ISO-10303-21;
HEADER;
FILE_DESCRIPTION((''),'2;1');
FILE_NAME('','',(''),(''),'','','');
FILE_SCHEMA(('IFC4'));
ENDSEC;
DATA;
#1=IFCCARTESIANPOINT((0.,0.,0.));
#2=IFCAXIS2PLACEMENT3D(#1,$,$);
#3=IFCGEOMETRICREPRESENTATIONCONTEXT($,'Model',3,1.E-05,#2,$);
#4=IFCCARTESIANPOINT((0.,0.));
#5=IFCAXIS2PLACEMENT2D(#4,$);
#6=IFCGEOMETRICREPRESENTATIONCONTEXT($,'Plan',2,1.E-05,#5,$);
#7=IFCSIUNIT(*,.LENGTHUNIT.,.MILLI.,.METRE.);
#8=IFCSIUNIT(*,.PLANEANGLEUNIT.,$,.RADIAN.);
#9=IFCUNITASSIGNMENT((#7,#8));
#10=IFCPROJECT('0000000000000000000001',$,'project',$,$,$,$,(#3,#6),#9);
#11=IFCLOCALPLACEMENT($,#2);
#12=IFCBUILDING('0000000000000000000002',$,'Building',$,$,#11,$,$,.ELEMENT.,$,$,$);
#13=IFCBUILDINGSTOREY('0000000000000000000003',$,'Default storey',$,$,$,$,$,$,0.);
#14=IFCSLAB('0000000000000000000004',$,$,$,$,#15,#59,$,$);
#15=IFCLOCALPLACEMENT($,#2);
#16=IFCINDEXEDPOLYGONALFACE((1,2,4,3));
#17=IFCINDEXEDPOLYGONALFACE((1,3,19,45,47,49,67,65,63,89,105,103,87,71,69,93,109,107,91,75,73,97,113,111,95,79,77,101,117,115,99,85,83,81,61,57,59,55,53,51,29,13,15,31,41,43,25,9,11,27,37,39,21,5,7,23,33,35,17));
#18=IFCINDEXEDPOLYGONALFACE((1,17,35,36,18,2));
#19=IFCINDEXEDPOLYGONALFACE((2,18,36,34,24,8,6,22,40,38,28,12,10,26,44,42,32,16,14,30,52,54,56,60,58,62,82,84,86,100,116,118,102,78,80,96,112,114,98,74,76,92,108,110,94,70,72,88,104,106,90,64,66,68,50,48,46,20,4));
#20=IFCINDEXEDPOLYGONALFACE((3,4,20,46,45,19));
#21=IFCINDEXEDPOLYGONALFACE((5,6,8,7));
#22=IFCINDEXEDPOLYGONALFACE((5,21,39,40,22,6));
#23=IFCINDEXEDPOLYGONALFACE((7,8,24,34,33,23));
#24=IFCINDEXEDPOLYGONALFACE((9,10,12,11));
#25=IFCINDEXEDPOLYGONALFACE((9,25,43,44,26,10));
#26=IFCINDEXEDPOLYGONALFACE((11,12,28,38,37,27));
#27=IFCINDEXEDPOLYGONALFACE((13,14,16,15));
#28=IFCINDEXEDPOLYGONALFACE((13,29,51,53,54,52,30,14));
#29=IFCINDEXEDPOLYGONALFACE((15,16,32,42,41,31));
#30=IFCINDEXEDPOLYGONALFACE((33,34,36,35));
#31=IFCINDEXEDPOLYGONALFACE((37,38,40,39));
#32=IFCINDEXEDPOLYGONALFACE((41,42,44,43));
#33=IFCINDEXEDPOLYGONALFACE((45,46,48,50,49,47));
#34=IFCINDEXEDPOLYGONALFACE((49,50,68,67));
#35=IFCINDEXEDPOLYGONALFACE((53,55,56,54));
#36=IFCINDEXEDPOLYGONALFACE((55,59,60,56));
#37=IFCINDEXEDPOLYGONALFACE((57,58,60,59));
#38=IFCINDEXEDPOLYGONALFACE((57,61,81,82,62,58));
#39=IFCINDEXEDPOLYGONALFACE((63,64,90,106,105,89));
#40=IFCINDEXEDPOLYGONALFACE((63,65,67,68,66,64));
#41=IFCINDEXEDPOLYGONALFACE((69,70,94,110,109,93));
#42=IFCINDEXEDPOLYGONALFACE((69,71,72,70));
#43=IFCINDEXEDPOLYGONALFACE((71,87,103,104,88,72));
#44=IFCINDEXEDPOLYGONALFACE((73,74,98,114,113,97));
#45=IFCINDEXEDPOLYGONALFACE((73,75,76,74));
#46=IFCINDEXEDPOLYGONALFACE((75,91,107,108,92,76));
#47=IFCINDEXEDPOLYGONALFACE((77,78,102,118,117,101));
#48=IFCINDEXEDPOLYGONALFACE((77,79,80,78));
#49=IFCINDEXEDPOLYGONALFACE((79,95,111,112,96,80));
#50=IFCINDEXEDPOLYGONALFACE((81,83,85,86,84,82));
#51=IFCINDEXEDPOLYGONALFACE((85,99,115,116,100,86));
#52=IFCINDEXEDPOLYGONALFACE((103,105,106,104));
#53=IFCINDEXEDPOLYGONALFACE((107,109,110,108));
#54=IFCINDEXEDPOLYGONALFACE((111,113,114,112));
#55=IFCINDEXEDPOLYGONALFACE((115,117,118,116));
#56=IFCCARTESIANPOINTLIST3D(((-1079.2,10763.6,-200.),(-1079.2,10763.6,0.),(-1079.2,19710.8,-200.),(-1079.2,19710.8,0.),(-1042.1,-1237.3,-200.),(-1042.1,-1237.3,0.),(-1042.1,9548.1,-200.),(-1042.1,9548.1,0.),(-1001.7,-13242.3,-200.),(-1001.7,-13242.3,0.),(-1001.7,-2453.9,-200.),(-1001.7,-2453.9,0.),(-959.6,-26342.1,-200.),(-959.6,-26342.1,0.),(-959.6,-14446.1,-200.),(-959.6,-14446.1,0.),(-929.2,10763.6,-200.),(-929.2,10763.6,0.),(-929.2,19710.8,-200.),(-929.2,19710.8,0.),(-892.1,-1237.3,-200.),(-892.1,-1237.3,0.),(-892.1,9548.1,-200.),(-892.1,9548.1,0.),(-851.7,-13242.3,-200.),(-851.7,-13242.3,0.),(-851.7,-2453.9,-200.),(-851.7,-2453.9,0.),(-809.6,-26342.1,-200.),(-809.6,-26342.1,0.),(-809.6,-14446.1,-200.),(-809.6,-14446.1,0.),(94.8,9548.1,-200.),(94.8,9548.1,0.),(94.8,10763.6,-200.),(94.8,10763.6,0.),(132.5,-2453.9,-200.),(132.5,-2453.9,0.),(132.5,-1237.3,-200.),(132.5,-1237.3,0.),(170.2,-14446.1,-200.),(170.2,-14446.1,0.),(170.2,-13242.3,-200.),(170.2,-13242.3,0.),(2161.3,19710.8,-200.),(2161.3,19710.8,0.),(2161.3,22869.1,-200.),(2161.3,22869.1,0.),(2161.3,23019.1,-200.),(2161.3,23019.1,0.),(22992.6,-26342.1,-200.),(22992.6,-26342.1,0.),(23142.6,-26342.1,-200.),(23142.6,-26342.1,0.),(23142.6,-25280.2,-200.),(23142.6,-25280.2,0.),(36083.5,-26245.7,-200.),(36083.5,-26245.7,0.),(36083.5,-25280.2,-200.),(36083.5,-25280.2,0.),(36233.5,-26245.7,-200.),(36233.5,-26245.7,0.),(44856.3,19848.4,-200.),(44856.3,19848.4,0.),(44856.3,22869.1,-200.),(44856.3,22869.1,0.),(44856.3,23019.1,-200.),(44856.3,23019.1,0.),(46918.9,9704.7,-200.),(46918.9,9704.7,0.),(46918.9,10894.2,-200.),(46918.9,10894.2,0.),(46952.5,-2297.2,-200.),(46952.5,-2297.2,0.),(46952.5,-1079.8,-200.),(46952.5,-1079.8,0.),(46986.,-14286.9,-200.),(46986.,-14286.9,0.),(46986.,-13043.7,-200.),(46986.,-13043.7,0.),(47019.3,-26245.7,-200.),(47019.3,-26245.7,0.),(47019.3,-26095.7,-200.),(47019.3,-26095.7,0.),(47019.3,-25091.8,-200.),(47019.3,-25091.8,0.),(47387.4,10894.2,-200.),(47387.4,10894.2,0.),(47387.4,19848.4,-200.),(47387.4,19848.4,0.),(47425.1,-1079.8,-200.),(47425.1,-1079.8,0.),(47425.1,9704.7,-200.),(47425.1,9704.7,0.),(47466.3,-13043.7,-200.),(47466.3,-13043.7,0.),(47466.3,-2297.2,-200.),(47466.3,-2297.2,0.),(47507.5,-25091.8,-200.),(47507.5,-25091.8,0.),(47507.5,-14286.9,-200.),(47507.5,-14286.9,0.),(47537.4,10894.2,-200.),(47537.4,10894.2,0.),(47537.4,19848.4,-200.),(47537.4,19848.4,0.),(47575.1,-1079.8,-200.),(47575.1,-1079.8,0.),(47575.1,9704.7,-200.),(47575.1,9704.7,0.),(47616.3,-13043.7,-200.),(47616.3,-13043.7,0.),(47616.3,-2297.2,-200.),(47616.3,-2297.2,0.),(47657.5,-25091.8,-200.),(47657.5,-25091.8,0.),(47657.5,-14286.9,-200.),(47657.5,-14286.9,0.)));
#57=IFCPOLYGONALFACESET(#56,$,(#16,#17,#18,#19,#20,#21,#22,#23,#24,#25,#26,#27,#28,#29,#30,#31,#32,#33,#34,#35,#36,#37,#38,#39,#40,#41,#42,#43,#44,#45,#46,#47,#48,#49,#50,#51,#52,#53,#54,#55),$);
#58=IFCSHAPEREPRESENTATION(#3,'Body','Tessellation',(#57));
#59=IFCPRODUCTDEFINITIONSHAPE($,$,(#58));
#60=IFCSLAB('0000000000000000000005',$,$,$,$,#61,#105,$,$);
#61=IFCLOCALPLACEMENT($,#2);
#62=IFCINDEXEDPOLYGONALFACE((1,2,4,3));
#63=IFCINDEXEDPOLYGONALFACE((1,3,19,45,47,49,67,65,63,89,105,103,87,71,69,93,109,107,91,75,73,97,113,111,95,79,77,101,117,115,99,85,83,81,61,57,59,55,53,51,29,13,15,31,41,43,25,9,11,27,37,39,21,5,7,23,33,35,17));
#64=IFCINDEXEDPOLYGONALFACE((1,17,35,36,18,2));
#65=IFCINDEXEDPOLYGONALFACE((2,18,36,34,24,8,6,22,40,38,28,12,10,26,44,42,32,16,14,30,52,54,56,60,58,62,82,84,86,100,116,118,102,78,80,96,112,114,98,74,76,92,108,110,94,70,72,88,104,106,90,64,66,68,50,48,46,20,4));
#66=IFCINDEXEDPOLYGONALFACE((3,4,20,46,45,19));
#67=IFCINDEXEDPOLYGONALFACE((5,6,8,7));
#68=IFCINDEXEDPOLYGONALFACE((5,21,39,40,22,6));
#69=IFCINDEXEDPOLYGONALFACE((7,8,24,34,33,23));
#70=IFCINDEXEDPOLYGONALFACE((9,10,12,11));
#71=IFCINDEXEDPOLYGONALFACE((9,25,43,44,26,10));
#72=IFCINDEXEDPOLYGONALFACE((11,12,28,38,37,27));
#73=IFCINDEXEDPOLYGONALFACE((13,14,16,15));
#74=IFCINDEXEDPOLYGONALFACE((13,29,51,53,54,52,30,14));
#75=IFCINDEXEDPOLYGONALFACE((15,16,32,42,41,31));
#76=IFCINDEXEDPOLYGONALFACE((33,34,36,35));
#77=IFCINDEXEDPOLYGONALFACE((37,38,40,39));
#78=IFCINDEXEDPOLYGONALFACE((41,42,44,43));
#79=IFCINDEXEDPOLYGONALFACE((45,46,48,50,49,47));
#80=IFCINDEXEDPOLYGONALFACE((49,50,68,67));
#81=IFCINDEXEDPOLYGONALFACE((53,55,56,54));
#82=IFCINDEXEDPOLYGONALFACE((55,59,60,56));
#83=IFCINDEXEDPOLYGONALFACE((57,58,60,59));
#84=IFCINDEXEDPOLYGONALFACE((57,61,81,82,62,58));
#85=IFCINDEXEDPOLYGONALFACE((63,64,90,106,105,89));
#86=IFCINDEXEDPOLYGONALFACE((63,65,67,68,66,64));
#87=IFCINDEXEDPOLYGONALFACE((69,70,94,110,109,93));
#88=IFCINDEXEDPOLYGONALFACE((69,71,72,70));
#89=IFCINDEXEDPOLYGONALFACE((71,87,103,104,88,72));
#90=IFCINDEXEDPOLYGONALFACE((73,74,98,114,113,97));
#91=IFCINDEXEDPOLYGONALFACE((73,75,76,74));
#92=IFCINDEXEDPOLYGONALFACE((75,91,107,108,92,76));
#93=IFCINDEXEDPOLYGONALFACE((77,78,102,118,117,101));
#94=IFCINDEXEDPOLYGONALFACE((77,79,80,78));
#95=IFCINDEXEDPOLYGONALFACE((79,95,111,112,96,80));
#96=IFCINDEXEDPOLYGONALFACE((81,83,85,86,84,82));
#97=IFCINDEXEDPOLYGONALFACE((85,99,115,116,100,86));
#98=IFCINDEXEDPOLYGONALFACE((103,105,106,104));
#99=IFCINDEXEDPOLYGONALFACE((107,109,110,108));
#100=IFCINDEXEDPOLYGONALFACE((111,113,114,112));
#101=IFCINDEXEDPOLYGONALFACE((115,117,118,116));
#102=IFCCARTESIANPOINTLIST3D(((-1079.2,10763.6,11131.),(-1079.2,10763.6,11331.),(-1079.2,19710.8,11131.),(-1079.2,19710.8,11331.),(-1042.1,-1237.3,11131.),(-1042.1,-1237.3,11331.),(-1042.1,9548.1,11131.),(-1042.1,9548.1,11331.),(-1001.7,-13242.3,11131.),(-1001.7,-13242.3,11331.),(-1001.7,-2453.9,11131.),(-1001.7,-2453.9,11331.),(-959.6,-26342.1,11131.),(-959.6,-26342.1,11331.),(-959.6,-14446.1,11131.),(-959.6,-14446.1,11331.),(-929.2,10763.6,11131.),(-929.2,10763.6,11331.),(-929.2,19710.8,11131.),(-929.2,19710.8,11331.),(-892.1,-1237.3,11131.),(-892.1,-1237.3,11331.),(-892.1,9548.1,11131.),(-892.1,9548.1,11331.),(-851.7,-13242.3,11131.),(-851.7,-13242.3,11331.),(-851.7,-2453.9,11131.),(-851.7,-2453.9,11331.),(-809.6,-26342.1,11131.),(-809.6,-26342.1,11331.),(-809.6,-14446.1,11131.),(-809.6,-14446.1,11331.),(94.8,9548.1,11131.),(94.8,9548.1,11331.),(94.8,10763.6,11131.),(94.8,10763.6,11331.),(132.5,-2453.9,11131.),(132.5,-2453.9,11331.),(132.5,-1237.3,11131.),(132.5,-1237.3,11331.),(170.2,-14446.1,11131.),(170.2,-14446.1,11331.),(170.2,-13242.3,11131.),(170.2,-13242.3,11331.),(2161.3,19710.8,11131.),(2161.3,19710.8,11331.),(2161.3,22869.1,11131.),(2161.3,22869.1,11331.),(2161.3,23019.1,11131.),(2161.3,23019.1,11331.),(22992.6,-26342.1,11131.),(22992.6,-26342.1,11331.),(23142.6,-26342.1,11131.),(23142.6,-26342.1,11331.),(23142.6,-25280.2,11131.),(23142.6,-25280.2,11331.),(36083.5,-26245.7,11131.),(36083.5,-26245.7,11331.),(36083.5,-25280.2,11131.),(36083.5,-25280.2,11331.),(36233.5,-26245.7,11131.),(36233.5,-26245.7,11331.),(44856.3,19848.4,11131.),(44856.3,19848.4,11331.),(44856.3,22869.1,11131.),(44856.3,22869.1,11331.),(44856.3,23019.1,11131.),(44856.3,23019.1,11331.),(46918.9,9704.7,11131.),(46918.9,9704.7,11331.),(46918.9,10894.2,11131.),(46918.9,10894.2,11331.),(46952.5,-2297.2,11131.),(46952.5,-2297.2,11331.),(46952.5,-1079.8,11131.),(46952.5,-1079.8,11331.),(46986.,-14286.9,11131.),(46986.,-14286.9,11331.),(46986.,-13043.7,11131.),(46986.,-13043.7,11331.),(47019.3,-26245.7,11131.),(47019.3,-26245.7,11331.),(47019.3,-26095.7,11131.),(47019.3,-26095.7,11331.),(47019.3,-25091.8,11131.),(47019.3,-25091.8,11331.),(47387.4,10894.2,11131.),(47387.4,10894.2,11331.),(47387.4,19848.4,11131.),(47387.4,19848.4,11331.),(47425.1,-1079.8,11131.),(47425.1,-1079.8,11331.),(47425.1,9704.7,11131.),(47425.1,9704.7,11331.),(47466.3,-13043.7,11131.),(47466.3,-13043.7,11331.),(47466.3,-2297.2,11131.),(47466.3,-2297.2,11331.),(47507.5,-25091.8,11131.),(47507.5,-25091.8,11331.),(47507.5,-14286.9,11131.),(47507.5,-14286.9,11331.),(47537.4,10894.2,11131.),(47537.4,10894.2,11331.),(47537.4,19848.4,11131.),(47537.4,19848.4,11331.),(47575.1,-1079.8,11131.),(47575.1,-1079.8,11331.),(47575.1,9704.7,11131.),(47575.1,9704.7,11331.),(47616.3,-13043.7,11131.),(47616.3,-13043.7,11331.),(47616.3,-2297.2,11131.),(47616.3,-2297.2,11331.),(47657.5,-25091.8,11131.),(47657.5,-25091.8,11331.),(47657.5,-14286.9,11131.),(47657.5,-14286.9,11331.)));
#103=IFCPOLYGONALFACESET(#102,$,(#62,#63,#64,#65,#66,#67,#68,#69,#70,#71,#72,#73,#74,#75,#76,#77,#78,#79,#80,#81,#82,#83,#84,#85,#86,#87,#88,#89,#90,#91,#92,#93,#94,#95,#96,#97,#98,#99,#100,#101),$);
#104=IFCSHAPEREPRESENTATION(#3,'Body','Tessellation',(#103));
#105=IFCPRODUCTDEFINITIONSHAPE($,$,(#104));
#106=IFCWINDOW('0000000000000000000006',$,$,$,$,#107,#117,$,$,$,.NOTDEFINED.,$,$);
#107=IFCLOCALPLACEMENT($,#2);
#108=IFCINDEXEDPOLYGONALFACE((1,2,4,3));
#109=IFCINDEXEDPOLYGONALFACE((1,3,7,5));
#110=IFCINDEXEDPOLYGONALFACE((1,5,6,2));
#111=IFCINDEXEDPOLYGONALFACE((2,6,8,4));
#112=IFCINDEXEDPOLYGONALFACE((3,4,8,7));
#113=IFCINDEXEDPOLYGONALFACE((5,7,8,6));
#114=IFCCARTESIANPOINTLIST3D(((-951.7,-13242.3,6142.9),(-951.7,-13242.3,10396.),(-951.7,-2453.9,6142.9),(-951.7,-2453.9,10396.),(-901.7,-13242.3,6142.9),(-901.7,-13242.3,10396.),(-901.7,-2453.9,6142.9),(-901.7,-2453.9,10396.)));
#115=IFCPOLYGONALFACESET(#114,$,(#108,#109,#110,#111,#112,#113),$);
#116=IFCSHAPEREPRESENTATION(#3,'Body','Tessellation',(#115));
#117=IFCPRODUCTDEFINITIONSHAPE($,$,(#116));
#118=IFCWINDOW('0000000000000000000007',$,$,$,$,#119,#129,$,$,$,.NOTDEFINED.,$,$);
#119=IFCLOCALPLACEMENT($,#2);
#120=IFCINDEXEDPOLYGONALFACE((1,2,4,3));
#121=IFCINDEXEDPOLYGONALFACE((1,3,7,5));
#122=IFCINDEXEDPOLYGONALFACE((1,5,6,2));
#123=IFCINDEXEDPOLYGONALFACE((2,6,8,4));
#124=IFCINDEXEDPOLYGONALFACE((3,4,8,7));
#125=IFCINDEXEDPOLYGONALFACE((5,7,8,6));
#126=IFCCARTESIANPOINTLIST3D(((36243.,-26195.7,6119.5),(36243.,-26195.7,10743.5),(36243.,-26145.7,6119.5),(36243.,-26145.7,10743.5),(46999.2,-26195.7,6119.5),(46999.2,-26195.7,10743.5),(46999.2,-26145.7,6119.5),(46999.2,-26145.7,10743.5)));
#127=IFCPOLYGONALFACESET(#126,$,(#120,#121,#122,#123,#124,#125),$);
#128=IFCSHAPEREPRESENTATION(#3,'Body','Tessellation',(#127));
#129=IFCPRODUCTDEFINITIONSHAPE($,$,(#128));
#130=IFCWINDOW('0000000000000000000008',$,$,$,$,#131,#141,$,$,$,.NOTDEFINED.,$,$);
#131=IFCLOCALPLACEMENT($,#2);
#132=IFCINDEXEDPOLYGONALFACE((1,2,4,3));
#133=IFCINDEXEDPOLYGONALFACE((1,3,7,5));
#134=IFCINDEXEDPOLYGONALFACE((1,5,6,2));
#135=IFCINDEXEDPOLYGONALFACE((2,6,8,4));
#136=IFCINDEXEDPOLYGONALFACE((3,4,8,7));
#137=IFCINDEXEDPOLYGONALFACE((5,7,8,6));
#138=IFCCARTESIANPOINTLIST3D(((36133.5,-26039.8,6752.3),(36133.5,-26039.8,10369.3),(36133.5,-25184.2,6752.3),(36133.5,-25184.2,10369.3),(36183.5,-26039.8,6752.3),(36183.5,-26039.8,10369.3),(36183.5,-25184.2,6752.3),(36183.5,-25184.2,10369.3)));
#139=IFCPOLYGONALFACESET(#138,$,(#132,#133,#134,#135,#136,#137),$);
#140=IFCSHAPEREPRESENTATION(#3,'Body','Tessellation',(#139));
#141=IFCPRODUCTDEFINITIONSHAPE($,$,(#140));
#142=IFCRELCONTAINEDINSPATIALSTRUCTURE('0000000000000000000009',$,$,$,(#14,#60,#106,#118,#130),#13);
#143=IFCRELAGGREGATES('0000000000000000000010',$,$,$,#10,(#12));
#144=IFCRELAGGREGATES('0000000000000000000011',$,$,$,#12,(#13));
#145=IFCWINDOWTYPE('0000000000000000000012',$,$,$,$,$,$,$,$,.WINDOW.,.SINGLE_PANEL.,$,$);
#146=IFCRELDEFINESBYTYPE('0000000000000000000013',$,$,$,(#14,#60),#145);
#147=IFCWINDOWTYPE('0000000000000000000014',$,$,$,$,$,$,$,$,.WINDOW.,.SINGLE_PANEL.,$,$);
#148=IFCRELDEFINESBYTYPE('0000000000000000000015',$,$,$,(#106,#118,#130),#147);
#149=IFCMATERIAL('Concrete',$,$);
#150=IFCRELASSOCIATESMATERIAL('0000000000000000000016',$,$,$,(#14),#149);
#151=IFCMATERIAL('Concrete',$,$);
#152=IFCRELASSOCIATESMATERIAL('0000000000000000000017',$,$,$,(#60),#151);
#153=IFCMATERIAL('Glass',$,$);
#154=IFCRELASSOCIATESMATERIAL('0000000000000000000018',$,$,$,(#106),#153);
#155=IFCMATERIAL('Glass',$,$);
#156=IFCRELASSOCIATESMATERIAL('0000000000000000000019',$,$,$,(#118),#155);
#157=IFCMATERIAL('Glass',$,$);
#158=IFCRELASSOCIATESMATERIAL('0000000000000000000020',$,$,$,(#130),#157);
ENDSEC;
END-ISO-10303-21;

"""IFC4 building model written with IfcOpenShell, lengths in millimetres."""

from ifc_helpers import new_model, si_unit, frame, origin, origin_2d, place, context, project, spatial, polyline, rectangle, outline, extrude, material, type_object, element, save


model = new_model("IFC4")

# Units and contexts
model_context = context("Model", 3, precision=1e-05, world=origin())
plan_context = context("Plan", 2, precision=1e-05, world=origin_2d())
ifc_project = project(units=[si_unit("LENGTHUNIT", "METRE", prefix="MILLI"), si_unit("PLANEANGLEUNIT", "RADIAN")], contexts=[model_context, plan_context])

# Building, storey
placement = place(None, origin())
building = spatial("IfcBuilding", under=ifc_project, at=placement, Name="Building", CompositionType="ELEMENT")
storey = spatial("IfcBuildingStorey", under=building, Name="Default storey", Elevation=0.0)

# Slabs
ifc_material_1 = material(Name="Concrete")
window_type_1 = type_object("IfcWindowType", PartitioningType="SINGLE_PANEL", PredefinedType="WINDOW")
element("IfcSlab", 1, at=placement, inside=storey, type_object=window_type_1, material=ifc_material_1, context=model_context, shape_type="SweptSolid", body=[
    extrude(outline(polyline([(46986.0, -14286.9), (46986.0, -13043.7), (47466.3, -13043.7), (47616.3, -13043.7), (47616.3, -2297.2), (47466.3, -2297.2), (46952.5, -2297.2), (46952.5, -1079.8), (47425.1, -1079.8), (47575.1, -1079.8), (47575.1, 9704.7), (47425.1, 9704.7), (46918.9, 9704.7), (46918.9, 10894.2), (47387.4, 10894.2), (47537.4, 10894.2), (47537.4, 19848.4), (47387.4, 19848.4), (44856.3, 19848.4), (44856.3, 22869.1), (44856.3, 23019.1), (2161.3, 23019.1), (2161.3, 22869.1), (2161.3, 19710.8), (-929.2, 19710.8), (-1079.2, 19710.8), (-1079.2, 10763.6), (-929.2, 10763.6), (94.8, 10763.6), (94.8, 9548.1), (-892.1, 9548.1), (-1042.1, 9548.1), (-1042.1, -1237.3), (-892.1, -1237.3), (132.5, -1237.3), (132.5, -2453.9), (-851.7, -2453.9), (-1001.7, -2453.9), (-1001.7, -13242.3), (-851.7, -13242.3), (170.2, -13242.3), (170.2, -14446.1), (-809.6, -14446.1), (-959.6, -14446.1), (-959.6, -26342.1), (-809.6, -26342.1), (22992.6, -26342.1), (23142.6, -26342.1), (23142.6, -25280.2), (36083.5, -25280.2), (36083.5, -26245.7), (36233.5, -26245.7), (47019.3, -26245.7), (47019.3, -26095.7), (47019.3, -25091.8), (47507.5, -25091.8), (47657.5, -25091.8), (47657.5, -14286.9), (47507.5, -14286.9), (46986.0, -14286.9)])), frame((0.0, 0.0, -200.0), z_axis=(0.0, 0.0, 1000.0), x_axis=(1000.0, 0.0, 0.0)), (0.0, 0.0, 1.0), 200.0),
])
ifc_material_2 = material(Name="Concrete")
element("IfcSlab", 2, at=placement, inside=storey, type_object=window_type_1, material=ifc_material_2, context=model_context, shape_type="SweptSolid", body=[
    extrude(outline(polyline([(46986.0, -14286.9), (46986.0, -13043.7), (47466.3, -13043.7), (47616.3, -13043.7), (47616.3, -2297.2), (47466.3, -2297.2), (46952.5, -2297.2), (46952.5, -1079.8), (47425.1, -1079.8), (47575.1, -1079.8), (47575.1, 9704.7), (47425.1, 9704.7), (46918.9, 9704.7), (46918.9, 10894.2), (47387.4, 10894.2), (47537.4, 10894.2), (47537.4, 19848.4), (47387.4, 19848.4), (44856.3, 19848.4), (44856.3, 22869.1), (44856.3, 23019.1), (2161.3, 23019.1), (2161.3, 22869.1), (2161.3, 19710.8), (-929.2, 19710.8), (-1079.2, 19710.8), (-1079.2, 10763.6), (-929.2, 10763.6), (94.8, 10763.6), (94.8, 9548.1), (-892.1, 9548.1), (-1042.1, 9548.1), (-1042.1, -1237.3), (-892.1, -1237.3), (132.5, -1237.3), (132.5, -2453.9), (-851.7, -2453.9), (-1001.7, -2453.9), (-1001.7, -13242.3), (-851.7, -13242.3), (170.2, -13242.3), (170.2, -14446.1), (-809.6, -14446.1), (-959.6, -14446.1), (-959.6, -26342.1), (-809.6, -26342.1), (22992.6, -26342.1), (23142.6, -26342.1), (23142.6, -25280.2), (36083.5, -25280.2), (36083.5, -26245.7), (36233.5, -26245.7), (47019.3, -26245.7), (47019.3, -26095.7), (47019.3, -25091.8), (47507.5, -25091.8), (47657.5, -25091.8), (47657.5, -14286.9), (47507.5, -14286.9), (46986.0, -14286.9)])), frame((0.0, 0.0, 11131.0), z_axis=(0.0, 0.0, 1000.0), x_axis=(1000.0, 0.0, 0.0)), (0.0, 0.0, 1.0), 200.0),
])

# Windows
ifc_material_3 = material(Name="Glass")
window_type_2 = type_object("IfcWindowType", PartitioningType="SINGLE_PANEL", PredefinedType="WINDOW")
element("IfcWindow", 3, at=placement, inside=storey, type_object=window_type_2, material=ifc_material_3, PredefinedType="NOTDEFINED", context=model_context, shape_type="CSG", body=[
    extrude(rectangle(XDim=10788.4, YDim=50.0, at=origin_2d()), frame((-926.7, -7848.1, 6142.9), z_axis=(0.0, 0.0, 1000.0), x_axis=(0.0, 10788.419962, 0.0)), (0.0, 0.0, 1.0), 4253.1),
])
ifc_material_4 = material(Name="Glass")
element("IfcWindow", 4, at=placement, inside=storey, type_object=window_type_2, material=ifc_material_4, PredefinedType="NOTDEFINED", context=model_context, shape_type="CSG", body=[
    extrude(rectangle(XDim=10756.2, YDim=50.0, at=origin_2d()), frame((41621.1, -26170.7, 6119.5), z_axis=(0.0, 0.0, 1000.0), x_axis=(10756.198883, 0.0, 0.0)), (0.0, 0.0, 1.0), 4624.0),
])
ifc_material_5 = material(Name="Glass")
element("IfcWindow", 5, at=placement, inside=storey, type_object=window_type_2, material=ifc_material_5, PredefinedType="NOTDEFINED", context=model_context, shape_type="CSG", body=[
    extrude(rectangle(XDim=855.6, YDim=50.0, at=origin_2d()), frame((36158.5, -25612.0, 6752.3), z_axis=(0.0, 0.0, 1000.0), x_axis=(0.0, 855.600357, 0.0)), (0.0, 0.0, 1.0), 3617.0),
])

save(model, "model.ifc")
